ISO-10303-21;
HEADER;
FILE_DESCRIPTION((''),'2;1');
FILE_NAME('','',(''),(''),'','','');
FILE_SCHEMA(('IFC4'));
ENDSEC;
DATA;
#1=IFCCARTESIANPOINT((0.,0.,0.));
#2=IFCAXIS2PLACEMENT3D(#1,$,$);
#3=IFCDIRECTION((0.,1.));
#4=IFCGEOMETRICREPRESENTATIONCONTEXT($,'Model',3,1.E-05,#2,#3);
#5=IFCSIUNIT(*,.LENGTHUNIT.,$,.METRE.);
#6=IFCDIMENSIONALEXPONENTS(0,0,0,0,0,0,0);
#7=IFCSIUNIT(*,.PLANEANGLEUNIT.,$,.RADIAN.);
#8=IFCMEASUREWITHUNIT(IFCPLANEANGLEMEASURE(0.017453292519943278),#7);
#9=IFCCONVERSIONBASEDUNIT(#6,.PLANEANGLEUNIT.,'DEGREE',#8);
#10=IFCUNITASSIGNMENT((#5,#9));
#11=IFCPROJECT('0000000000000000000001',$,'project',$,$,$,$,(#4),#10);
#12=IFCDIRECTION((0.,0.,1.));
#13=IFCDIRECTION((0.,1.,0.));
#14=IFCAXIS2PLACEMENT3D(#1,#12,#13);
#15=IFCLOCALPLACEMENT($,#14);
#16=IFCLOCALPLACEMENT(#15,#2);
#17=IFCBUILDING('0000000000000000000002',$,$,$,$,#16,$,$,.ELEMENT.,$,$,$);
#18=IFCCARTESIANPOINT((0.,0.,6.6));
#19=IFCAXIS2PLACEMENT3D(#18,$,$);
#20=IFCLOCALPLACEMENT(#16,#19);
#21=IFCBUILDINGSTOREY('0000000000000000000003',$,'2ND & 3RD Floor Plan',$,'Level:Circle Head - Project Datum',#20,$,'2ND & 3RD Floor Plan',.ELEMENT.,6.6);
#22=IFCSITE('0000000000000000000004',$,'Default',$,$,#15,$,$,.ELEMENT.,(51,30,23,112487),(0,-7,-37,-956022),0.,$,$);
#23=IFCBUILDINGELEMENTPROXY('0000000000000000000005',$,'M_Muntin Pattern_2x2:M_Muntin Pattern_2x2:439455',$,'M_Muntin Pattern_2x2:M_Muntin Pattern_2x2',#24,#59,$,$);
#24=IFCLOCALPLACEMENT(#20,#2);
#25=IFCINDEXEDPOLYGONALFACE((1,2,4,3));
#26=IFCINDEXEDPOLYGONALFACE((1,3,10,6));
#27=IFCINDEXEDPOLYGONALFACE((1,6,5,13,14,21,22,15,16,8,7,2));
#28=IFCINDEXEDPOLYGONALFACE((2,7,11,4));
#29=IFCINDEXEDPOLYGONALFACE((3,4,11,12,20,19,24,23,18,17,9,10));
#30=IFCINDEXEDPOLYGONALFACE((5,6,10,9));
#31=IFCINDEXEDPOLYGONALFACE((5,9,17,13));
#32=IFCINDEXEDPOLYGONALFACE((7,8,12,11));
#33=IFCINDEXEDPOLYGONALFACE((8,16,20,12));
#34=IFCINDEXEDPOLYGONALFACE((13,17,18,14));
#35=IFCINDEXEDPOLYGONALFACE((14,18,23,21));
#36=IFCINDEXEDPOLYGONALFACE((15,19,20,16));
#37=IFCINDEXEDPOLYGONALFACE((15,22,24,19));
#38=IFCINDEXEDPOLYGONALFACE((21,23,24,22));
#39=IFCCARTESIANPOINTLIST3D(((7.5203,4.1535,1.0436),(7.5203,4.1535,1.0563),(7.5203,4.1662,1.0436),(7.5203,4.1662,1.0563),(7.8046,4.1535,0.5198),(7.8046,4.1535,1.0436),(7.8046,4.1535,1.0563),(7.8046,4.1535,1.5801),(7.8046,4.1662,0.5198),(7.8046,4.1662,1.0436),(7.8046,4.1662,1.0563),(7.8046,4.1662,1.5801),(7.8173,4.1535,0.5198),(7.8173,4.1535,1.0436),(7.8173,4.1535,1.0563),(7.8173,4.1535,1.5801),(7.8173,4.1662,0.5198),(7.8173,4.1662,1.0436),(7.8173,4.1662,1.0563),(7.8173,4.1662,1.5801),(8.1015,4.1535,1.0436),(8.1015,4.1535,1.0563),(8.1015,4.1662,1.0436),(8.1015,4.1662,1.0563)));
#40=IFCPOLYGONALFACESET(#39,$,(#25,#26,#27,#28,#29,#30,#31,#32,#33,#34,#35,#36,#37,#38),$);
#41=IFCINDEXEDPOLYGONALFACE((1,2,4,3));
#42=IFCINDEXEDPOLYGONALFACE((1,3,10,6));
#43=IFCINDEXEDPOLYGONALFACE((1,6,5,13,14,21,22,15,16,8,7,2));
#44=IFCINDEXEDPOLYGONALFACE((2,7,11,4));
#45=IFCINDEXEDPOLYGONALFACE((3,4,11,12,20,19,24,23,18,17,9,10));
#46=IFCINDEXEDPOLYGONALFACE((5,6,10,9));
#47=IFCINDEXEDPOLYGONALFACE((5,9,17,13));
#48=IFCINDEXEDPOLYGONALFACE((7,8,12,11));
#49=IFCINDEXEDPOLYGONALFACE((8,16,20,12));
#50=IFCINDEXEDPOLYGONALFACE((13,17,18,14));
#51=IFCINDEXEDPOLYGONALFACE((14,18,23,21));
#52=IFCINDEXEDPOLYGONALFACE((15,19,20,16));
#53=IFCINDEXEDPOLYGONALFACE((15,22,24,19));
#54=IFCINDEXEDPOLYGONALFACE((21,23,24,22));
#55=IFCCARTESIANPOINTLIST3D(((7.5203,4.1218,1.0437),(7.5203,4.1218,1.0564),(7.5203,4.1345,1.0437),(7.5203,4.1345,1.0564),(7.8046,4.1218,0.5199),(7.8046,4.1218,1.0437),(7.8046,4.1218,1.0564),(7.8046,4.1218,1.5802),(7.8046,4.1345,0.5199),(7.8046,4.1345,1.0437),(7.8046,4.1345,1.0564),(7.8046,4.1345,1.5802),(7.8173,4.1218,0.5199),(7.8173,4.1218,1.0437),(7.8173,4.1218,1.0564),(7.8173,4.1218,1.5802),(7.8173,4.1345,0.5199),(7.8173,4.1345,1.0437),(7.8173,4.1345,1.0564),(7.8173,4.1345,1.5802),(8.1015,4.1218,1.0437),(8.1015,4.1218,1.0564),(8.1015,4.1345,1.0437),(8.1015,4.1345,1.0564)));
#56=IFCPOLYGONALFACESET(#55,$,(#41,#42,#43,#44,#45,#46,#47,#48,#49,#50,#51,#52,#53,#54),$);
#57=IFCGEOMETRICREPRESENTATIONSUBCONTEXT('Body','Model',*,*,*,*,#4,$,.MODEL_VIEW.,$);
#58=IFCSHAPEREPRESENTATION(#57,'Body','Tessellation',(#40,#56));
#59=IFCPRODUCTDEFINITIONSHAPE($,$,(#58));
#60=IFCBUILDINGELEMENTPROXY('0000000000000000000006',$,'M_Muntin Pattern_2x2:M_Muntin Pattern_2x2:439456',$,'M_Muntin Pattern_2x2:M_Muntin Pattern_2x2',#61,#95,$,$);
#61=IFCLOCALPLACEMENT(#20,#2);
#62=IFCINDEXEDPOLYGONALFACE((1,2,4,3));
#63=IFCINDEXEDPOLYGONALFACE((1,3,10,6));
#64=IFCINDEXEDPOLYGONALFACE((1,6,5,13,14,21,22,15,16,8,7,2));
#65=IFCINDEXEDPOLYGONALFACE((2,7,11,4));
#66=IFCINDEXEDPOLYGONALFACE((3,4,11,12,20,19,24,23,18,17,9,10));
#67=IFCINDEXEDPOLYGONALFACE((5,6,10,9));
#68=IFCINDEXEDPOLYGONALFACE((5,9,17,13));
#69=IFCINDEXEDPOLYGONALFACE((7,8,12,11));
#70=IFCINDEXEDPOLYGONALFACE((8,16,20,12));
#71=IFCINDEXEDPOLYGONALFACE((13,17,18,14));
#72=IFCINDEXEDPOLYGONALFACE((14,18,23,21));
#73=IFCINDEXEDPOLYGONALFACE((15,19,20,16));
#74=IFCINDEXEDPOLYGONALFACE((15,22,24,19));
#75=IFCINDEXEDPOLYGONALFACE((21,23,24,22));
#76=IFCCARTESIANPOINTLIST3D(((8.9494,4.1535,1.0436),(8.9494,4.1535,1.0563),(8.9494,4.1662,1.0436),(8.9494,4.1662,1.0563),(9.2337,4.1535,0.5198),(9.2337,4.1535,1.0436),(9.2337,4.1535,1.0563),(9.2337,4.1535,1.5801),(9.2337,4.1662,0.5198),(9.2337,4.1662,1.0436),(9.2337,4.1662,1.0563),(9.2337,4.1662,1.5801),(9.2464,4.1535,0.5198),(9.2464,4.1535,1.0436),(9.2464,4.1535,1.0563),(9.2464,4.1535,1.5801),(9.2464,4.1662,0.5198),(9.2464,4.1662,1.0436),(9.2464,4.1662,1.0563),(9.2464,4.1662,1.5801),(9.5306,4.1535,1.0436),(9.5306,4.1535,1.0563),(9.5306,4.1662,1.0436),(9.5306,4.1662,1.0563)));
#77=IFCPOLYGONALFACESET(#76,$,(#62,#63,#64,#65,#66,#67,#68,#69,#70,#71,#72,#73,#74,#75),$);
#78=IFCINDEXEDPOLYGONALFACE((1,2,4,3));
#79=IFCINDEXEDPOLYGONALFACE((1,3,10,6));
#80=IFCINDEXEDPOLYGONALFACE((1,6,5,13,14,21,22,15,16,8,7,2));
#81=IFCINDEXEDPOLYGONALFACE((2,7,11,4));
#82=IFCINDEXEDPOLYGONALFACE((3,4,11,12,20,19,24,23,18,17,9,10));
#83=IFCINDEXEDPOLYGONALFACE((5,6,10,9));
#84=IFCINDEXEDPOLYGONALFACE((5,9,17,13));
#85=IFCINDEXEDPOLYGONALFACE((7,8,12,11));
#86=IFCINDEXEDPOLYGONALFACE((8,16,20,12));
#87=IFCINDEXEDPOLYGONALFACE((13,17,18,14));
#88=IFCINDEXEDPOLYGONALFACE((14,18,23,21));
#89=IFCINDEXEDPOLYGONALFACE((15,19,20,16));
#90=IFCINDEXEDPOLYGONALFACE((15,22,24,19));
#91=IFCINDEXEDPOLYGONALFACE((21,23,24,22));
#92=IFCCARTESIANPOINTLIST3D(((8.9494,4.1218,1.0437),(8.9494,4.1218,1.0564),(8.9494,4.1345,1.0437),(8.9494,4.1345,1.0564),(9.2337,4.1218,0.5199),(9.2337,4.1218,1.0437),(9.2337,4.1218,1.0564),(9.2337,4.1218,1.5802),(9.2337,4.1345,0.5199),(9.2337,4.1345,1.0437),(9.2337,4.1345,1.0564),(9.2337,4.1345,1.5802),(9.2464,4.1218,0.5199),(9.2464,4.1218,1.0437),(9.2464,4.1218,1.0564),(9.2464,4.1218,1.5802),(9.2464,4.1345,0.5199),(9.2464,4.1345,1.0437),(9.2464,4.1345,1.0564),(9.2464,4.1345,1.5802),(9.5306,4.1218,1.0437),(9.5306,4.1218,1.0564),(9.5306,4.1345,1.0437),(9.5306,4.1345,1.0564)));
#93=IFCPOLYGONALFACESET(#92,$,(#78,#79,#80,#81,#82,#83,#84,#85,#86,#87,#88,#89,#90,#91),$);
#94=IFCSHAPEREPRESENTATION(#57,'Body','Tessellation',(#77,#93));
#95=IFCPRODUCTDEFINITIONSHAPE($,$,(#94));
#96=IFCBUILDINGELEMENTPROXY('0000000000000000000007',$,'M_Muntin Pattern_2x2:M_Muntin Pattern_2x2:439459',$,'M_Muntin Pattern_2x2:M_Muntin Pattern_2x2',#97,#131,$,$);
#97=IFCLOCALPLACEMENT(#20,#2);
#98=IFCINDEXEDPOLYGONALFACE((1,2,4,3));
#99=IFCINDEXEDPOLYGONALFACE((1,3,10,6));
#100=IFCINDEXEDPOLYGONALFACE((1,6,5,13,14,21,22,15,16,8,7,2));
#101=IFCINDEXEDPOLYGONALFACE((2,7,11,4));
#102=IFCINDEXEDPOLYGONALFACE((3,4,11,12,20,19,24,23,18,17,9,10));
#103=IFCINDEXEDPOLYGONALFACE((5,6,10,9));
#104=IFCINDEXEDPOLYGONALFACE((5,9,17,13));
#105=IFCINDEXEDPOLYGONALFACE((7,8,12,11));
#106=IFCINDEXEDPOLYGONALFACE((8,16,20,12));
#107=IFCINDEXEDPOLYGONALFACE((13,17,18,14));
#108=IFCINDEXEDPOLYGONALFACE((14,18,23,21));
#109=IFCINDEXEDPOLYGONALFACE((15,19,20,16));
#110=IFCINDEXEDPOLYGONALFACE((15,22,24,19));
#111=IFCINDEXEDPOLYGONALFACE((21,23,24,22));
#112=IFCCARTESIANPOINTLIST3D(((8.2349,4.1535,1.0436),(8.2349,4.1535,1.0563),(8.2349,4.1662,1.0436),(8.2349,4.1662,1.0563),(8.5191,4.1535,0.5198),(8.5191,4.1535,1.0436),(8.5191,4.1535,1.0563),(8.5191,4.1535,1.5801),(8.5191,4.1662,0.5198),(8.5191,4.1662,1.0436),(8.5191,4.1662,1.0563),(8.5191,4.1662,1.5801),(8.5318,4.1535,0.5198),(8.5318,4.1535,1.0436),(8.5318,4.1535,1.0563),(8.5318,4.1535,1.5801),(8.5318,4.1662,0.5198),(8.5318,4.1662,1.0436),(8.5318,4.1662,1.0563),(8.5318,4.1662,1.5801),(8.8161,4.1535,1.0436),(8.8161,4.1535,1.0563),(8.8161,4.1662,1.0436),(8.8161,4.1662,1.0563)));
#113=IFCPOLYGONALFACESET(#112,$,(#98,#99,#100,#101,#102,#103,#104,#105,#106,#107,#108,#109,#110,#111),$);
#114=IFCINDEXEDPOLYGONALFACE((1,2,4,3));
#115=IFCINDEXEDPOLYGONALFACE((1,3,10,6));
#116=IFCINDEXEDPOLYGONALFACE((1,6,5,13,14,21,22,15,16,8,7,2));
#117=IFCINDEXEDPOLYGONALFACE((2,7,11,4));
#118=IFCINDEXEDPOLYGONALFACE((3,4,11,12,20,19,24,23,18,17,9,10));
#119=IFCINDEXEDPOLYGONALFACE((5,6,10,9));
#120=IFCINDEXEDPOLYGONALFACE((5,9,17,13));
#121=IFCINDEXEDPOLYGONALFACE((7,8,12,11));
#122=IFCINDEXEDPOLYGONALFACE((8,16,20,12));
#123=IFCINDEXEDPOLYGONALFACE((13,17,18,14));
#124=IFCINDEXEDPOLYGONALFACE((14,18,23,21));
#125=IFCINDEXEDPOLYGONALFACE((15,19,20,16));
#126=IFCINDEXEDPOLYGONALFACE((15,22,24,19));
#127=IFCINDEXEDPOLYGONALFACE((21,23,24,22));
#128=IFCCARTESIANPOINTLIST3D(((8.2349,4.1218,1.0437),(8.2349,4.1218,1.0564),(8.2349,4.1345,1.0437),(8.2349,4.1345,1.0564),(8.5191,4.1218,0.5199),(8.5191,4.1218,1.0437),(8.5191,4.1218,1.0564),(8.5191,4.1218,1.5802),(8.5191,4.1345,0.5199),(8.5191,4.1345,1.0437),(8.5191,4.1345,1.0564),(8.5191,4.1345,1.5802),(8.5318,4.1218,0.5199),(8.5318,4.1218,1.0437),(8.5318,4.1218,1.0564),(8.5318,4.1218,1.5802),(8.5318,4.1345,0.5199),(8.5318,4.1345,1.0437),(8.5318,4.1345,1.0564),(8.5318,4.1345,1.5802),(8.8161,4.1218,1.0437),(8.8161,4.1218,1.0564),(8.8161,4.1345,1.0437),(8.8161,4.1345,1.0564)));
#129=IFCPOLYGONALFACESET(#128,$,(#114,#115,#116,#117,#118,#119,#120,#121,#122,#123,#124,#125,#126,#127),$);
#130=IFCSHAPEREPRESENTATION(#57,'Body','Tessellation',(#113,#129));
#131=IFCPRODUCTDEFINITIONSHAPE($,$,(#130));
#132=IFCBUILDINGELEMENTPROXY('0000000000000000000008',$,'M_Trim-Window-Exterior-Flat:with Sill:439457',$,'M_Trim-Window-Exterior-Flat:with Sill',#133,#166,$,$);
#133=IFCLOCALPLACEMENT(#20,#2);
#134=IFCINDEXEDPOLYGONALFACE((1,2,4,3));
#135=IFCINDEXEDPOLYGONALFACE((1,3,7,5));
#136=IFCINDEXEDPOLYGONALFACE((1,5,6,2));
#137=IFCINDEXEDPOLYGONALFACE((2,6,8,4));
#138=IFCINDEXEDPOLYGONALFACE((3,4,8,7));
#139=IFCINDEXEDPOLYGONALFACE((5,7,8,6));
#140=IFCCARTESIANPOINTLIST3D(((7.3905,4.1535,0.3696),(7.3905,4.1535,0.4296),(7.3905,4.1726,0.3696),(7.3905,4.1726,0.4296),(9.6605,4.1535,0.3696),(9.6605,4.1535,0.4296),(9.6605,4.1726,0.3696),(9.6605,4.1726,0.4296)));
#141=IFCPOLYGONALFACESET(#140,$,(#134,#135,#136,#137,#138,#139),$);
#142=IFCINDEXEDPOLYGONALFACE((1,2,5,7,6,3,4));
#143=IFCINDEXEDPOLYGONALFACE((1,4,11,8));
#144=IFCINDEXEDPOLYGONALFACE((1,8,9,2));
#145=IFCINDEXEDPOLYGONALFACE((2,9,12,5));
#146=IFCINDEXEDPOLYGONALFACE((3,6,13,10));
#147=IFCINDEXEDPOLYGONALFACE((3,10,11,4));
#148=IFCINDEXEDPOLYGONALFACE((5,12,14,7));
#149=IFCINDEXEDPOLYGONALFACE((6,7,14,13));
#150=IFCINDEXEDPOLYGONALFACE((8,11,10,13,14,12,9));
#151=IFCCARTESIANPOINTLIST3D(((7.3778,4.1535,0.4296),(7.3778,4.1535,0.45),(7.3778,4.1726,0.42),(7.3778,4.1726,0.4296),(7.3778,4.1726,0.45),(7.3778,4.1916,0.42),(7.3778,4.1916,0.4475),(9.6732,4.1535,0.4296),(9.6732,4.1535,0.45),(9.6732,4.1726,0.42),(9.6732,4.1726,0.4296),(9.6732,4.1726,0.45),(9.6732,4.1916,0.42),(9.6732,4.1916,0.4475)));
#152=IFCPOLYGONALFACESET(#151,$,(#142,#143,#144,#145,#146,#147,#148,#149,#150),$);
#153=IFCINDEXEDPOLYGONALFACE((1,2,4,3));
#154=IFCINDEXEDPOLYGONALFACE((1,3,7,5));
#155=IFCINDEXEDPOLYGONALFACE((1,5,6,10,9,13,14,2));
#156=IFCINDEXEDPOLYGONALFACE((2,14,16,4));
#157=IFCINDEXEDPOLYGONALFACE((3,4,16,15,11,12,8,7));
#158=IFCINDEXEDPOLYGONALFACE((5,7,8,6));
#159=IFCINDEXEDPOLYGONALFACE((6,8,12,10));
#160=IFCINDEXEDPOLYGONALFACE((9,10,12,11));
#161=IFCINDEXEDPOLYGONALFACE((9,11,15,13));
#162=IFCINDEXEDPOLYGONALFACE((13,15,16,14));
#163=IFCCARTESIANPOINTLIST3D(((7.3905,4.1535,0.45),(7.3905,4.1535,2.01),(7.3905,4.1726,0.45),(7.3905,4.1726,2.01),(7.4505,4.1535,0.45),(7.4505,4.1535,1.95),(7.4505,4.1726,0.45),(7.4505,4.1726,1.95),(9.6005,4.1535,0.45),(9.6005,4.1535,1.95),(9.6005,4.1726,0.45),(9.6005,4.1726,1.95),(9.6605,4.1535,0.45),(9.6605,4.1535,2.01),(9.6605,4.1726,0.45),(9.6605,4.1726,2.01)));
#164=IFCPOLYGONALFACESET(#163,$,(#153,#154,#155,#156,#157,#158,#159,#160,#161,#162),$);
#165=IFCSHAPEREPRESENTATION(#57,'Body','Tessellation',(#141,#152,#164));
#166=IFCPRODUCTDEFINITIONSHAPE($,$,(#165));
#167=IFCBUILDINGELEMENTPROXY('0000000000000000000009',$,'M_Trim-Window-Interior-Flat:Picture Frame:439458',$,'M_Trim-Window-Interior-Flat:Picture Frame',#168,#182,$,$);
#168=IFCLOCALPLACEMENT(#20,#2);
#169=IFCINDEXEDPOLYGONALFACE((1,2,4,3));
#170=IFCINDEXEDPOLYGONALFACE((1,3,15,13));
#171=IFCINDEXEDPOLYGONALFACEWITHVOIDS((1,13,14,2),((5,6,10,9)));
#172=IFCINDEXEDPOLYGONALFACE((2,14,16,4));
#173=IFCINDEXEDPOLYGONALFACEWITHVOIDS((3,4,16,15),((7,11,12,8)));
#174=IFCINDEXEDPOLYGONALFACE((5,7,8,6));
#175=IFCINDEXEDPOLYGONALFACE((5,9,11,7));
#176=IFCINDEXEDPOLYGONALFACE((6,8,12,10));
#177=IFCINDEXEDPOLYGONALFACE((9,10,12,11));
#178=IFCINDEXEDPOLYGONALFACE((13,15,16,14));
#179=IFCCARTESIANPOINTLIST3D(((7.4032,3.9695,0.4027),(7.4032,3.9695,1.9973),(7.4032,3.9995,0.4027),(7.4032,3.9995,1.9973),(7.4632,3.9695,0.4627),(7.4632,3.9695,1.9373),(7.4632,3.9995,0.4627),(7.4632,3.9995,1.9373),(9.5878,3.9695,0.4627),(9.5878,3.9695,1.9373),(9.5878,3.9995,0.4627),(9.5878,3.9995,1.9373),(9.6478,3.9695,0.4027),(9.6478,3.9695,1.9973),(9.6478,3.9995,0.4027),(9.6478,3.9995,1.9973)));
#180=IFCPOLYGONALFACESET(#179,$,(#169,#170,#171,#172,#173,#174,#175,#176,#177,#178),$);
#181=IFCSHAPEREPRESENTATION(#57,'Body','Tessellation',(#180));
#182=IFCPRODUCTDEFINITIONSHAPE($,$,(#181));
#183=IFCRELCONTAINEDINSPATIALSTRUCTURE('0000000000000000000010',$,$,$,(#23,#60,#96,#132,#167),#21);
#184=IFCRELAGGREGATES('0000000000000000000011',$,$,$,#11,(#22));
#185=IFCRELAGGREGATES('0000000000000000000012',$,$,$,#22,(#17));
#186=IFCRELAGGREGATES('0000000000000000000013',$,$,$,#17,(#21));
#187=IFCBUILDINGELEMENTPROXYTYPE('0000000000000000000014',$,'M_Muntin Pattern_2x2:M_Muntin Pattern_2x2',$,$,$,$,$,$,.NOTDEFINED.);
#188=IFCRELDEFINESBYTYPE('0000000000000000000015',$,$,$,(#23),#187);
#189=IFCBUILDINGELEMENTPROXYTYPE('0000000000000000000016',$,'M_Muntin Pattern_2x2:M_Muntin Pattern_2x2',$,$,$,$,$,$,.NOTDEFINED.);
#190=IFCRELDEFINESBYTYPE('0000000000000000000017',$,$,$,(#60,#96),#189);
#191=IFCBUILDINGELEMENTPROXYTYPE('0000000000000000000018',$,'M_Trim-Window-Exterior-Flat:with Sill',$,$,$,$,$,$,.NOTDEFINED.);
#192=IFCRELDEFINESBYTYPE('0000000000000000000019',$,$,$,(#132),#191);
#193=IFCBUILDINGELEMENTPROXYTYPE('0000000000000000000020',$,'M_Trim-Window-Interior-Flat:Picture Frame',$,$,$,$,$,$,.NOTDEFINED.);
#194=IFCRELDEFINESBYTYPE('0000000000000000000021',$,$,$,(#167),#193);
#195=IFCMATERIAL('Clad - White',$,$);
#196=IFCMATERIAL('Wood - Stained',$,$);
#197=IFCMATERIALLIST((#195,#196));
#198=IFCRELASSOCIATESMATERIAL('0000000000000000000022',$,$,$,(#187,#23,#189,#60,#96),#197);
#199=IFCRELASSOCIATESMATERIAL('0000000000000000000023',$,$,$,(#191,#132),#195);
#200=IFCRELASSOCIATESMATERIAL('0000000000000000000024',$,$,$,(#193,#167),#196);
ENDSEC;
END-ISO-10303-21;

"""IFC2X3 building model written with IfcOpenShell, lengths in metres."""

from ifc_helpers import new_model, entity, si_unit, converted_unit, direction, frame, frame_2d, origin, place, context, subcontext, project, spatial, polyline, rectangle, outline, extrude, source, transform, mapped, material, material_list, type_object, type_shapes, element, save


model = new_model("IFC2X3")

# Units and contexts
model_context = context("Model", 3, precision=1e-05, world=origin(), true_north=direction((0.0, 1.0)))
body_context = subcontext(model_context, "Body", "Model", "MODEL_VIEW")
ifc_project = project(units=[si_unit("LENGTHUNIT", "METRE"), converted_unit("PLANEANGLEUNIT", "DEGREE", entity("IfcPlaneAngleMeasure", 0.017453292519943278), si_unit("PLANEANGLEUNIT", "RADIAN"), dimensions=[0, 0, 0, 0, 0, 0, 0])], contexts=[model_context])

# Site, building, storey
site_placement = place(None, frame((0.0, 0.0, 0.0), z_axis=(0.0, 0.0, 1.0), x_axis=(0.0, 1.0, 0.0)))
site = spatial("IfcSite", under=ifc_project, at=site_placement, Name="Default", CompositionType="ELEMENT", RefLatitude=(51, 30, 23, 112487), RefLongitude=(0, -7, -37, -956022), RefElevation=0.0)
building_placement = place(site_placement, origin())
building = spatial("IfcBuilding", under=site, at=building_placement, CompositionType="ELEMENT")
storey_placement = place(building_placement, frame((0.0, 0.0, 6.6)))
storey = spatial("IfcBuildingStorey", under=building, at=storey_placement, Name="2ND & 3RD Floor Plan", ObjectType="Level:Circle Head - Project Datum", LongName="2ND & 3RD Floor Plan", CompositionType="ELEMENT", Elevation=6.6)

# Building element proxies
ifc_material_1 = material(Name="Clad - White")
ifc_material_2 = material(Name="Wood - Stained")
ifc_material_list = material_list([ifc_material_1, ifc_material_2])
building_element_proxy_type_1 = type_object("IfcBuildingElementProxyType", Name="M_Muntin Pattern_2x2:M_Muntin Pattern_2x2", PredefinedType="NOTDEFINED", material=ifc_material_list)
shared_shape_1 = source(origin(), body_context, "Body", "SweptSolid", [
    extrude(outline(polyline([(0.0064, -0.0064), (0.5301, -0.0064), (0.5301, 0.0063), (0.0064, 0.0063), (0.0064, 0.2906), (-0.0063, 0.2906), (-0.0063, 0.0063), (-0.5302, 0.0063), (-0.5302, -0.0064), (-0.0063, -0.0064), (-0.0063, -0.2906), (0.0064, -0.2906), (0.0064, -0.0064)])), frame((0.0, 0.0095, 0.5301), z_axis=(0.0, 1.0, 0.0), x_axis=(0.0, 0.0, 1.0)), (0.0, 0.0, 1.0), 0.0127),
    extrude(outline(polyline([(0.0064, -0.0064), (0.5302, -0.0064), (0.5302, 0.0063), (0.0064, 0.0063), (0.0064, 0.2906), (-0.0063, 0.2906), (-0.0063, 0.0063), (-0.5302, 0.0063), (-0.5302, -0.0064), (-0.0063, -0.0064), (-0.0063, -0.2906), (0.0064, -0.2906), (0.0064, -0.0064)])), frame((0.0, -0.0222, 0.5302), z_axis=(0.0, 1.0, 0.0), x_axis=(0.0, 0.0, 1.0)), (0.0, 0.0, 1.0), 0.0127),
])
type_shapes(building_element_proxy_type_1, [shared_shape_1])
proxy_1_placement = place(storey_placement, frame((7.8109, 4.144, 0.5199)))
element("IfcBuildingElementProxy", 1, at=proxy_1_placement, inside=storey, type_object=building_element_proxy_type_1, material=ifc_material_list, Name="M_Muntin Pattern_2x2:M_Muntin Pattern_2x2:439455", ObjectType="M_Muntin Pattern_2x2:M_Muntin Pattern_2x2", context=body_context, shape_type="MappedRepresentation", body=[
    mapped(shared_shape_1, transform((0.0, 0.0, 0.0), scale=1.0)),
])
building_element_proxy_type_2 = type_object("IfcBuildingElementProxyType", Name="M_Muntin Pattern_2x2:M_Muntin Pattern_2x2", PredefinedType="NOTDEFINED", material=ifc_material_list)
shared_shape_2 = source(origin(), body_context, "Body", "SweptSolid", [
    extrude(outline(polyline([(0.0064, -0.0064), (0.5301, -0.0064), (0.5301, 0.0063), (0.0064, 0.0063), (0.0064, 0.2906), (-0.0063, 0.2906), (-0.0063, 0.0063), (-0.5302, 0.0063), (-0.5302, -0.0064), (-0.0063, -0.0064), (-0.0063, -0.2906), (0.0064, -0.2906), (0.0064, -0.0064)])), frame((0.0, -0.0222, 0.5301), z_axis=(0.0, 1.0, 0.0), x_axis=(0.0, 0.0, 1.0)), (0.0, 0.0, 1.0), 0.0127),
    extrude(outline(polyline([(0.0064, -0.0064), (0.5302, -0.0064), (0.5302, 0.0063), (0.0064, 0.0063), (0.0064, 0.2906), (-0.0063, 0.2906), (-0.0063, 0.0063), (-0.5302, 0.0063), (-0.5302, -0.0064), (-0.0063, -0.0064), (-0.0063, -0.2906), (0.0064, -0.2906), (0.0064, -0.0064)])), frame((0.0, 0.0095, 0.5302), z_axis=(0.0, 1.0, 0.0), x_axis=(0.0, 0.0, 1.0)), (0.0, 0.0, 1.0), 0.0127),
])
type_shapes(building_element_proxy_type_2, [shared_shape_2])
for number, where, z_axis, x_axis, name in (
    (2, (9.24, 4.144, 0.5199), (0.0, 0.0, 1.0), (-1.0, 0.0, 0.0), "M_Muntin Pattern_2x2:M_Muntin Pattern_2x2:439456"),
    (3, (8.5255, 4.144, 0.5199), (0.0, 0.0, 1.0), (-1.0, 0.0, 0.0), "M_Muntin Pattern_2x2:M_Muntin Pattern_2x2:439459"),
):
    element("IfcBuildingElementProxy", number, at=place(storey_placement, frame(where, z_axis=z_axis, x_axis=x_axis)), inside=storey, type_object=building_element_proxy_type_2, material=ifc_material_list, Name=name, ObjectType="M_Muntin Pattern_2x2:M_Muntin Pattern_2x2", context=body_context, shape_type="MappedRepresentation", body=[
        mapped(shared_shape_2, transform((0.0, 0.0, 0.0), scale=1.0)),
    ])
building_element_proxy_type_3 = type_object("IfcBuildingElementProxyType", Name="M_Trim-Window-Exterior-Flat:with Sill", PredefinedType="NOTDEFINED", material=ifc_material_1)
shared_shape_3 = source(origin(), body_context, "Body", "SweptSolid", [
    extrude(rectangle(XDim=2.27, YDim=0.06, at=frame_2d((0.0, 0.0), x_axis=(1.0, 0.0))), frame((0.0, -1.5504, 0.0), z_axis=(0.0, 0.0, 1.0), x_axis=(-1.0, 0.0, 0.0)), (0.0, 0.0, 1.0), 0.019),
    extrude(outline(polyline([(-0.019, -0.0152), (0.0, -0.0152), (0.0, -0.0057), (0.019, -0.0057), (0.019, 0.0148), (0.0, 0.0148), (-0.019, 0.0123), (-0.019, -0.0152)])), frame((-1.1477, -1.5148, 0.019), z_axis=(1.0, 0.0, 0.0), x_axis=(0.0, 0.0, -1.0)), (0.0, 0.0, 1.0), 2.2954),
    extrude(outline(polyline([(-0.795, -1.135), (0.765, -1.135), (0.765, -1.075), (-0.735, -1.075), (-0.735, 1.075), (0.765, 1.075), (0.765, 1.135), (-0.795, 1.135), (-0.795, -1.135)])), frame((0.0, -0.735, 0.0), z_axis=(0.0, 0.0, 1.0), x_axis=(0.0, -1.0, 0.0)), (0.0, 0.0, 1.0), 0.019),
])
type_shapes(building_element_proxy_type_3, [shared_shape_3])
proxy_2_placement = place(storey_placement, frame((8.5255, 4.1535, 1.95), z_axis=(0.0, 1.0, 0.0), x_axis=(-1.0, 0.0, 0.0)))
element("IfcBuildingElementProxy", 4, at=proxy_2_placement, inside=storey, type_object=building_element_proxy_type_3, material=ifc_material_1, Name="M_Trim-Window-Exterior-Flat:with Sill:439457", ObjectType="M_Trim-Window-Exterior-Flat:with Sill", context=body_context, shape_type="MappedRepresentation", body=[
    mapped(shared_shape_3, transform((0.0, 0.0, 0.0), scale=1.0)),
])
building_element_proxy_type_4 = type_object("IfcBuildingElementProxyType", Name="M_Trim-Window-Interior-Flat:Picture Frame", PredefinedType="NOTDEFINED", material=ifc_material_2)
shared_shape_4 = source(origin(), body_context, "Body", "SweptSolid", [
    extrude(outline(polyline([(-1.1223, -0.7973), (1.1223, -0.7973), (1.1223, 0.7973), (-1.1223, 0.7973), (-1.1223, -0.7973)]), holes=[polyline([(-1.0623, -0.7373), (-1.0623, 0.7373), (1.0623, 0.7373), (1.0623, -0.7373), (-1.0623, -0.7373)])]), frame((0.0, -0.75, 0.0), z_axis=(0.0, 0.0, 1.0), x_axis=(-1.0, 0.0, 0.0)), (0.0, 0.0, 1.0), 0.03),
])
type_shapes(building_element_proxy_type_4, [shared_shape_4])
proxy_3_placement = place(storey_placement, frame((8.5255, 3.9995, 1.95), z_axis=(0.0, -1.0, 0.0), x_axis=(1.0, 0.0, 0.0)))
element("IfcBuildingElementProxy", 5, at=proxy_3_placement, inside=storey, type_object=building_element_proxy_type_4, material=ifc_material_2, Name="M_Trim-Window-Interior-Flat:Picture Frame:439458", ObjectType="M_Trim-Window-Interior-Flat:Picture Frame", context=body_context, shape_type="MappedRepresentation", body=[
    mapped(shared_shape_4, transform((0.0, 0.0, 0.0), scale=1.0)),
])

save(model, "model.ifc")
